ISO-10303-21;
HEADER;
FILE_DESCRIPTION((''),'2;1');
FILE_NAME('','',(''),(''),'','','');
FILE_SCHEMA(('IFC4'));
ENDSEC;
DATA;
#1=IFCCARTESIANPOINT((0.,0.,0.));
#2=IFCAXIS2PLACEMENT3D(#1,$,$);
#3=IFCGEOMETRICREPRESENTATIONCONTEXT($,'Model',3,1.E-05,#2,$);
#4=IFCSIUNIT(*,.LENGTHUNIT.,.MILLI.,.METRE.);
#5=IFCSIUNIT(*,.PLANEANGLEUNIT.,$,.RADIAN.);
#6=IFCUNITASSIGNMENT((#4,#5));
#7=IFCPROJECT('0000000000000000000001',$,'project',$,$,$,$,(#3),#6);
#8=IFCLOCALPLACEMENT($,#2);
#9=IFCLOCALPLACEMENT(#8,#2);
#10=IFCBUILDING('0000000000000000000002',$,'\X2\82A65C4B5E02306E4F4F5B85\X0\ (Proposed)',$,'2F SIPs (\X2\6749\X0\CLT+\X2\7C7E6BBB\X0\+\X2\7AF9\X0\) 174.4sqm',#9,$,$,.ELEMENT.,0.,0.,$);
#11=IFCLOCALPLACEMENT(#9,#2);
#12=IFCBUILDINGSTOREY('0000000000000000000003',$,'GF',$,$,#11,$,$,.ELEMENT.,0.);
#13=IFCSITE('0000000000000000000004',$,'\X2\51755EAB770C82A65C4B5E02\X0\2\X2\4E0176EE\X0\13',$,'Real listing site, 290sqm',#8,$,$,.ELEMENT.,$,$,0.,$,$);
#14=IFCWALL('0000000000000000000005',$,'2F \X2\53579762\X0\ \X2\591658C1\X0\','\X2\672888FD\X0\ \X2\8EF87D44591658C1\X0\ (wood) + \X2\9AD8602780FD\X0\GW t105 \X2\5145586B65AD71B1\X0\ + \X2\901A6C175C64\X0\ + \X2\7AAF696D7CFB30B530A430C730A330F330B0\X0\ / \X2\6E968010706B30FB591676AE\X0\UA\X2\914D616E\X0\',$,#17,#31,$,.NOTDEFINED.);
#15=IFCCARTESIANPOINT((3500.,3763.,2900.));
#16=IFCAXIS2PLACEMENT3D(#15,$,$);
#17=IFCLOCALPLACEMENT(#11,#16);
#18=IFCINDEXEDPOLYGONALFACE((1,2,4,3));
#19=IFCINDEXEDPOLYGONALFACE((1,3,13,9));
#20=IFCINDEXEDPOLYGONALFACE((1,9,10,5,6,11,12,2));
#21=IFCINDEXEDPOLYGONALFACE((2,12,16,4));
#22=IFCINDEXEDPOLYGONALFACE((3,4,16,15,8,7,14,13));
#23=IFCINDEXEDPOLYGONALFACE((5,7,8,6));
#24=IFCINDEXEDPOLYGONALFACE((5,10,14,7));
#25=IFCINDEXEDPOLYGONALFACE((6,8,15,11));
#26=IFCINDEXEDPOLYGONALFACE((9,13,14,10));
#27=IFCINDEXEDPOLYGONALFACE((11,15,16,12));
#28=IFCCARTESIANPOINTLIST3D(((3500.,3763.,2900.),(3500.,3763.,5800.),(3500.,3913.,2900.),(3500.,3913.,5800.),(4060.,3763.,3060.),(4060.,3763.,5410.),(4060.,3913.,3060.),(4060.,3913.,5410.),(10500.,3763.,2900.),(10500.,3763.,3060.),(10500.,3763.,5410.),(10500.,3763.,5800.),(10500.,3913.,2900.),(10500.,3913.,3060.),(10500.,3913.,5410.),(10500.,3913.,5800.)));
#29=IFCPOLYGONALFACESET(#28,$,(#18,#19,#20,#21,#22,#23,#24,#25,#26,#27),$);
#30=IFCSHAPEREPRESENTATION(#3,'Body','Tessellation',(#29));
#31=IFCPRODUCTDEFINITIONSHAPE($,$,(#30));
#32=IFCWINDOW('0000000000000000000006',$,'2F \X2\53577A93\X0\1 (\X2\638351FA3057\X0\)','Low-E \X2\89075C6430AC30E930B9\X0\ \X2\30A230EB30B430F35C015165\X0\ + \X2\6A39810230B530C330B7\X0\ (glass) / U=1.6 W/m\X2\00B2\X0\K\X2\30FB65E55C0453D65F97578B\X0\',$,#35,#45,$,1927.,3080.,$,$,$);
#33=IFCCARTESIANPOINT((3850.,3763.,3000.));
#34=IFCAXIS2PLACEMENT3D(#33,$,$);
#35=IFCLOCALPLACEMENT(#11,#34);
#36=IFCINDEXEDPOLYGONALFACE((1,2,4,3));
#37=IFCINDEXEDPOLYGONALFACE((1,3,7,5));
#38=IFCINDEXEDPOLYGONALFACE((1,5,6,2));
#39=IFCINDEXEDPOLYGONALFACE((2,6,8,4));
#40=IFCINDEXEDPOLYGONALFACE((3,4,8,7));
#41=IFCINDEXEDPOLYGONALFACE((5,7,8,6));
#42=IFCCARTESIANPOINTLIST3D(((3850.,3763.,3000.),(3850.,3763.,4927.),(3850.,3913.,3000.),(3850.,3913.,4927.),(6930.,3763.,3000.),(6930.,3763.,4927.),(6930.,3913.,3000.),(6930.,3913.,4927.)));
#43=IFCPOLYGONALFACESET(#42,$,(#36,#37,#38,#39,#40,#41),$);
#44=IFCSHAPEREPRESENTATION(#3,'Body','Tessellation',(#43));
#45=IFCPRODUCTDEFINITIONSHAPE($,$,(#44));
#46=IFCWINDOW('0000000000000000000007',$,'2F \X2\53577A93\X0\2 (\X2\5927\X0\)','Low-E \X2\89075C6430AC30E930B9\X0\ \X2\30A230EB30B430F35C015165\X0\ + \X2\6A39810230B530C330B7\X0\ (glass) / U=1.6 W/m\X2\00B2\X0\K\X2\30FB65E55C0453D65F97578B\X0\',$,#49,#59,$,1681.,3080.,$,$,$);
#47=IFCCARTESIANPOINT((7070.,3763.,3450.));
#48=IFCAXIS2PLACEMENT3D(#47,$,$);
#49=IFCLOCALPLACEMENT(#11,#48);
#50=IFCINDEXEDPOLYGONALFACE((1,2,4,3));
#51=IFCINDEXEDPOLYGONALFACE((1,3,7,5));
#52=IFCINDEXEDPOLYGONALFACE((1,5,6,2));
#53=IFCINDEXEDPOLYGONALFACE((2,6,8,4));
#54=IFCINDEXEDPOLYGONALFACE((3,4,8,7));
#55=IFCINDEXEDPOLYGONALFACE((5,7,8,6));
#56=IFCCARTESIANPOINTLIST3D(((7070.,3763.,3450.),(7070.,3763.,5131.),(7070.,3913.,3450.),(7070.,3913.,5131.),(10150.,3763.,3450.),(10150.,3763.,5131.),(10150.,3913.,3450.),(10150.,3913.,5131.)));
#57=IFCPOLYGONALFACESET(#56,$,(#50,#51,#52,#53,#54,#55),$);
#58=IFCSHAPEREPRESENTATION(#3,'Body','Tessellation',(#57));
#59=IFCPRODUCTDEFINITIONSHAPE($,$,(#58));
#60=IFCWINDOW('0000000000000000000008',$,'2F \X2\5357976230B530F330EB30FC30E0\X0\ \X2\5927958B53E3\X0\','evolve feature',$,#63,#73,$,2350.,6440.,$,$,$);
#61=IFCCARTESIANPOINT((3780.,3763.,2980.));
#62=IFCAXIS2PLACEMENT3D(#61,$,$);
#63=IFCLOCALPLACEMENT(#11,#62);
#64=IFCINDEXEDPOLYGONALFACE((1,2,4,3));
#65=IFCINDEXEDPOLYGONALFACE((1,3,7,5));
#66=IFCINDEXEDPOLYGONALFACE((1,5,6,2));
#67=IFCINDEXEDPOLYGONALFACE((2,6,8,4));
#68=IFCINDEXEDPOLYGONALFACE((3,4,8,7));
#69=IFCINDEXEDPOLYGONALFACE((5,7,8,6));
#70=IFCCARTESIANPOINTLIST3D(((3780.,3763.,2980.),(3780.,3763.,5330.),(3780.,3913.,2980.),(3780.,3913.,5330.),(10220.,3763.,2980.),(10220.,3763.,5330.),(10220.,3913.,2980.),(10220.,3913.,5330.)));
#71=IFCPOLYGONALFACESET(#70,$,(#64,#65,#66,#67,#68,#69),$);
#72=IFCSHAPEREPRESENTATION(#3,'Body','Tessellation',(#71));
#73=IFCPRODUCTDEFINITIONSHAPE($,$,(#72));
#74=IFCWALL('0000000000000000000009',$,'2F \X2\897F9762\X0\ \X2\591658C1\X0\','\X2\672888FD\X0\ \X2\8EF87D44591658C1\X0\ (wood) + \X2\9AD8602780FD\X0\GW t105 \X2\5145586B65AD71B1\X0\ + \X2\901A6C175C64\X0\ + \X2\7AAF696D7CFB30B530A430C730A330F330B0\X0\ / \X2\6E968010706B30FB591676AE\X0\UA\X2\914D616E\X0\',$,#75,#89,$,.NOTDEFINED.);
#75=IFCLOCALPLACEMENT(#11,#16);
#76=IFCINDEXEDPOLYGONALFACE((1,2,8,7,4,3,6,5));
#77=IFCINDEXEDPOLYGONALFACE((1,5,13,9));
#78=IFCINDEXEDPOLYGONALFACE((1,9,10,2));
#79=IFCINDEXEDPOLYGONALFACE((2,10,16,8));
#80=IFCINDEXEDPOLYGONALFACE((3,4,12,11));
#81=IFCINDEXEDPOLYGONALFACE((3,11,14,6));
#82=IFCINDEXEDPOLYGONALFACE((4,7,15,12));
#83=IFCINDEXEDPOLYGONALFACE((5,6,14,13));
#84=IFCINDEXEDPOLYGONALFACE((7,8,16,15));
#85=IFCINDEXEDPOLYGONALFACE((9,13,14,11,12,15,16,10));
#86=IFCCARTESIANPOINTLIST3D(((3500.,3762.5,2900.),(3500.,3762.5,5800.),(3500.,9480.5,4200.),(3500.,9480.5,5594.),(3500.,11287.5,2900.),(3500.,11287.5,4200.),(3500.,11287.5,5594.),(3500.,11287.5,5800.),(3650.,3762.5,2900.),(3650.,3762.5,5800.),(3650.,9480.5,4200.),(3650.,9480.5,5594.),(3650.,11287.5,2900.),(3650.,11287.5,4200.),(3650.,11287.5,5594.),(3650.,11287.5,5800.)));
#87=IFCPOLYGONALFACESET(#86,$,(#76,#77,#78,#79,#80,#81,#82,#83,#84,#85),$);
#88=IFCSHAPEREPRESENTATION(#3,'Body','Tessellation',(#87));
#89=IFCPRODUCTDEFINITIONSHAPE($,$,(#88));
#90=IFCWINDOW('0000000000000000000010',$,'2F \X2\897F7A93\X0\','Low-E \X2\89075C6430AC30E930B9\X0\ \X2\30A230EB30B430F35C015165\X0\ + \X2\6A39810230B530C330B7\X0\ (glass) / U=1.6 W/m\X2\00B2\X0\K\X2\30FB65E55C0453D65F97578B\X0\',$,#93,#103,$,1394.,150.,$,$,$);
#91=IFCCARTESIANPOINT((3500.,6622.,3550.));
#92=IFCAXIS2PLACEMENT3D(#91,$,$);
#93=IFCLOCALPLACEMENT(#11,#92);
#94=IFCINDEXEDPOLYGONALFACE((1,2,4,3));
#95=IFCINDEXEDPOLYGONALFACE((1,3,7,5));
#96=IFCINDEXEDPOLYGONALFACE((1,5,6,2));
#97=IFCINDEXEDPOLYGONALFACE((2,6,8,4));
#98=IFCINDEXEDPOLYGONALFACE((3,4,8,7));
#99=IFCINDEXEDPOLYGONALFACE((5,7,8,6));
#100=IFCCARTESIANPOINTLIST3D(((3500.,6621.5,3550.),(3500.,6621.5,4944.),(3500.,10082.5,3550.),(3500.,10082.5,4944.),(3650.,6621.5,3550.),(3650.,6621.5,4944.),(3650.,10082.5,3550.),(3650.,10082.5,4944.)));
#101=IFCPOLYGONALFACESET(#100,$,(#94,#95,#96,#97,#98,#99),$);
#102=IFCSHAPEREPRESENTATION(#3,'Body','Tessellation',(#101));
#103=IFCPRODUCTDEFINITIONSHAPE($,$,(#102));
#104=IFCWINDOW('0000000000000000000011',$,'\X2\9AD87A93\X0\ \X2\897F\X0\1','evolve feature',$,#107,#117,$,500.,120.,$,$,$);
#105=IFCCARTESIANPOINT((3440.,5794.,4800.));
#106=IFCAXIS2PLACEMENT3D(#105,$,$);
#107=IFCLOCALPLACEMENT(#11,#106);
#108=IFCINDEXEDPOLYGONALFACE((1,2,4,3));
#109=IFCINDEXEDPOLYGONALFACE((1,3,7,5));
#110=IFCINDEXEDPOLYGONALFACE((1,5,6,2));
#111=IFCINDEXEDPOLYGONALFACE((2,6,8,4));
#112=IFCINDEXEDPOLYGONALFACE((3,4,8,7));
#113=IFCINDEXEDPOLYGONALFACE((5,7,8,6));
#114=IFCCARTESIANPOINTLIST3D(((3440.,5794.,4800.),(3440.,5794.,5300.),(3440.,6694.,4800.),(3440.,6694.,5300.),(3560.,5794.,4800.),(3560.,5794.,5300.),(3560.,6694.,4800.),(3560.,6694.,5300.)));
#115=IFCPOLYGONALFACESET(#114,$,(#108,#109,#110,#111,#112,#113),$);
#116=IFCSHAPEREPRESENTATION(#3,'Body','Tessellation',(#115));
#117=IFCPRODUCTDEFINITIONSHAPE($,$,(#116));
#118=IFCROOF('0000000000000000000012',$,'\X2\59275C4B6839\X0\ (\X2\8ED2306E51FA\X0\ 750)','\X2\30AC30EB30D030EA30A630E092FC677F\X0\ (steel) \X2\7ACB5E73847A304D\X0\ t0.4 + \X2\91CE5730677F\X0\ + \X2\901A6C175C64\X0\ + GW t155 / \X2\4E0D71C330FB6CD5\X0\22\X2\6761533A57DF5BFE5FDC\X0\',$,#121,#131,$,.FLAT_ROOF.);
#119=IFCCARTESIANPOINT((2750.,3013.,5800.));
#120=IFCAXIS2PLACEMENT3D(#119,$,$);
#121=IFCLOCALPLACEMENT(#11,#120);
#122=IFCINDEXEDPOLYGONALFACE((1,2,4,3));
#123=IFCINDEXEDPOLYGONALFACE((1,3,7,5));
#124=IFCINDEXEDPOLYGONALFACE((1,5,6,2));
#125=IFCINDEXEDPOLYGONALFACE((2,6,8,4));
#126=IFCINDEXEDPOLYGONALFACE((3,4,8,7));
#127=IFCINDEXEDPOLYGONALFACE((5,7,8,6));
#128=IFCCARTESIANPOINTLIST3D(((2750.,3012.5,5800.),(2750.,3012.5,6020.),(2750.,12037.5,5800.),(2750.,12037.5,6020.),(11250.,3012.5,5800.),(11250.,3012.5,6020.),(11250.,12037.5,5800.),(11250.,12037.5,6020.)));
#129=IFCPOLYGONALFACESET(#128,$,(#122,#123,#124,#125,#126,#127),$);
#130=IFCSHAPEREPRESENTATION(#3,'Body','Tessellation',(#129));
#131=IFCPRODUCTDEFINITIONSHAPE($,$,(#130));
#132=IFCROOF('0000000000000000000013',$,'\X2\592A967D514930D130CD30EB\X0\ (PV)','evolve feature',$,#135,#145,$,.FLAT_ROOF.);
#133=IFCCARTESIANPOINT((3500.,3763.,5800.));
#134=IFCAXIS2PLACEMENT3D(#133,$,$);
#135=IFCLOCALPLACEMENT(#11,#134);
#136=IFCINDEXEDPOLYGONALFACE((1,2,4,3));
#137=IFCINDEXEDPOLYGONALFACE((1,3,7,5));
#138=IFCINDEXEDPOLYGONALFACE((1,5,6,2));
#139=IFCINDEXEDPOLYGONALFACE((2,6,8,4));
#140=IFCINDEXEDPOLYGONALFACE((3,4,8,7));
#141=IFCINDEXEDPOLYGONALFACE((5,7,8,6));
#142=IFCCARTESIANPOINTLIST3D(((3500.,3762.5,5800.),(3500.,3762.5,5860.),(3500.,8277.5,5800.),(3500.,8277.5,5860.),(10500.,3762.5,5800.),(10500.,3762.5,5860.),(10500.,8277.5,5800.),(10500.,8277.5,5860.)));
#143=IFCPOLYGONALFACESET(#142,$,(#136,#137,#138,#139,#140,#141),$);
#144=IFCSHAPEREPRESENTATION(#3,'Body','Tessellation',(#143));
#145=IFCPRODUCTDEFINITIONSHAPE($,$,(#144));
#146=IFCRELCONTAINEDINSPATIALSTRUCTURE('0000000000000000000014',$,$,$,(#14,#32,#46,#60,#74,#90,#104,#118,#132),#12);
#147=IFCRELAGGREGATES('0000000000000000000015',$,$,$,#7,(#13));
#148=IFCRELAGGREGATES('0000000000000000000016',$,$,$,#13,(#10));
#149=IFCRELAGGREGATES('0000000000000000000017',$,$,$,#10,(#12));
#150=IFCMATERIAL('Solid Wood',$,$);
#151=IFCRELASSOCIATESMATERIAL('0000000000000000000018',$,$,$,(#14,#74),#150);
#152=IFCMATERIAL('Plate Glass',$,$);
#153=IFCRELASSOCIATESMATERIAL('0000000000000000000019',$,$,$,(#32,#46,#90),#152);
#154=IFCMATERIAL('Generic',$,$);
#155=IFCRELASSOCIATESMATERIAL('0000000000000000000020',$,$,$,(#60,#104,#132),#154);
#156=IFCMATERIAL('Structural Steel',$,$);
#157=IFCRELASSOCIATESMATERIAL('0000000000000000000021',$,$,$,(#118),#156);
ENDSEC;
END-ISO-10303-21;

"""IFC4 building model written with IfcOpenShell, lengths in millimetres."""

from ifc_helpers import new_model, si_unit, frame, frame_2d, origin, place, context, project, spatial, rectangle, extrude, material, element, fill, save


model = new_model("IFC4")

# Units and contexts
model_context = context("Model", 3, precision=1e-05, world=origin())
ifc_project = project(units=[si_unit("LENGTHUNIT", "METRE", prefix="MILLI"), si_unit("PLANEANGLEUNIT", "RADIAN")], contexts=[model_context])

# Site, building, storey
site_placement = place(None, origin())
site = spatial("IfcSite", under=ifc_project, at=site_placement, Name="兵庫県芦屋市2丁目13", ObjectType="Real listing site, 290sqm", CompositionType="ELEMENT", RefElevation=0.0)
building_placement = place(site_placement, origin())
building = spatial("IfcBuilding", under=site, at=building_placement, Name="芦屋市の住宅 (Proposed)", ObjectType="2F SIPs (杉CLT+籾殻+竹) 174.4sqm", CompositionType="ELEMENT", ElevationOfRefHeight=0.0, ElevationOfTerrain=0.0)
storey_placement = place(building_placement, origin())
storey = spatial("IfcBuildingStorey", under=building, at=storey_placement, Name="GF", CompositionType="ELEMENT", Elevation=0.0)

# Shared definitions
ifc_material_1 = material(Name="Solid Wood")
ifc_material_2 = material(Name="Generic")

# Shared definitions
ifc_material_3 = material(Name="Plate Glass")

# Walls, openings, windows
wall_1_placement = place(storey_placement, frame((3500.0, 3763.0, 2900.0)))
wall_1 = element("IfcWall", 1, at=wall_1_placement, inside=storey, material=ifc_material_1, Name="2F 南面 外壁", Description="木製 軸組外壁 (wood) + 高性能GW t105 充填断熱 + 通気層 + 窯業系サイディング / 準耐火・外皮UA配慮", PredefinedType="NOTDEFINED", context=model_context, shape_type="SweptSolid", body=[
    extrude(rectangle(XDim=7000.0, YDim=150.0, at=frame_2d((3500.0, 75.0))), frame((3500.0, 3763.0, 2900.0)), (0.0, 0.0, 1.0), 2900.0),
])
opening_1_placement = place(storey_placement, frame((3850.0, 3763.0, 3000.0)))
opening_1 = element("IfcOpeningElement", 2, at=opening_1_placement, cuts=wall_1, PredefinedType="NOTDEFINED", context=model_context, shape_type="SweptSolid", body=[
    extrude(rectangle(XDim=3080.0, YDim=150.0, at=frame_2d((1540.0, 75.0))), frame((3850.0, 3763.0, 3000.0)), (0.0, 0.0, 1.0), 1927.0),
])
opening_2_placement = place(storey_placement, frame((7070.0, 3763.0, 3450.0)))
opening_2 = element("IfcOpeningElement", 3, at=opening_2_placement, cuts=wall_1, PredefinedType="NOTDEFINED", context=model_context, shape_type="SweptSolid", body=[
    extrude(rectangle(XDim=3080.0, YDim=150.0, at=frame_2d((1540.0, 75.0))), frame((7070.0, 3763.0, 3450.0)), (0.0, 0.0, 1.0), 1681.0),
])
opening_3_placement = place(storey_placement, frame((3780.0, 3763.0, 2980.0)))
opening_3 = element("IfcOpeningElement", 4, at=opening_3_placement, cuts=wall_1, PredefinedType="NOTDEFINED", context=model_context, shape_type="SweptSolid", body=[
    extrude(rectangle(XDim=6440.0, YDim=150.0, at=frame_2d((3220.0, 75.0))), frame((3780.0, 3763.0, 2980.0)), (0.0, 0.0, 1.0), 2350.0),
])
window_1_placement = place(storey_placement, frame((3850.0, 3763.0, 3000.0)))
window_1 = element("IfcWindow", 5, at=window_1_placement, inside=storey, material=ifc_material_3, Name="2F 南窓1 (掃出し)", Description="Low-E 複層ガラス アルゴン封入 + 樹脂サッシ (glass) / U=1.6 W/m²K・日射取得型", OverallHeight=1927.0, OverallWidth=3080.0, context=model_context, shape_type="SweptSolid", body=[
    extrude(rectangle(XDim=3080.0, YDim=150.0, at=frame_2d((1540.0, 75.0))), frame((3850.0, 3763.0, 3000.0)), (0.0, 0.0, 1.0), 1927.0),
])
fill(opening_1, window_1)
window_2_placement = place(storey_placement, frame((7070.0, 3763.0, 3450.0)))
window_2 = element("IfcWindow", 6, at=window_2_placement, inside=storey, material=ifc_material_3, Name="2F 南窓2 (大)", Description="Low-E 複層ガラス アルゴン封入 + 樹脂サッシ (glass) / U=1.6 W/m²K・日射取得型", OverallHeight=1681.0, OverallWidth=3080.0, context=model_context, shape_type="SweptSolid", body=[
    extrude(rectangle(XDim=3080.0, YDim=150.0, at=frame_2d((1540.0, 75.0))), frame((7070.0, 3763.0, 3450.0)), (0.0, 0.0, 1.0), 1681.0),
])
fill(opening_2, window_2)
window_3_placement = place(storey_placement, frame((3780.0, 3763.0, 2980.0)))
window_3 = element("IfcWindow", 7, at=window_3_placement, inside=storey, material=ifc_material_2, Name="2F 南面サンルーム 大開口", Description="evolve feature", OverallHeight=2350.0, OverallWidth=6440.0, context=model_context, shape_type="SweptSolid", body=[
    extrude(rectangle(XDim=6440.0, YDim=150.0, at=frame_2d((3220.0, 75.0))), frame((3780.0, 3763.0, 2980.0)), (0.0, 0.0, 1.0), 2350.0),
])
fill(opening_3, window_3)
wall_2_placement = place(storey_placement, frame((3500.0, 3763.0, 2900.0)))
wall_2 = element("IfcWall", 8, at=wall_2_placement, inside=storey, material=ifc_material_1, Name="2F 西面 外壁", Description="木製 軸組外壁 (wood) + 高性能GW t105 充填断熱 + 通気層 + 窯業系サイディング / 準耐火・外皮UA配慮", PredefinedType="NOTDEFINED", context=model_context, shape_type="SweptSolid", body=[
    extrude(rectangle(XDim=150.0, YDim=7525.0, at=frame_2d((75.0, 3762.0))), frame((3500.0, 3763.0, 2900.0)), (0.0, 0.0, 1.0), 2900.0),
])
opening_4_placement = place(storey_placement, frame((3500.0, 6622.0, 3550.0)))
opening_4 = element("IfcOpeningElement", 9, at=opening_4_placement, cuts=wall_2, PredefinedType="NOTDEFINED", context=model_context, shape_type="SweptSolid", body=[
    extrude(rectangle(XDim=150.0, YDim=3461.0, at=frame_2d((75.0, 1730.0))), frame((3500.0, 6622.0, 3550.0)), (0.0, 0.0, 1.0), 1394.0),
])
opening_5_placement = place(storey_placement, frame((3440.0, 5794.0, 4800.0)))
opening_5 = element("IfcOpeningElement", 10, at=opening_5_placement, cuts=wall_2, PredefinedType="NOTDEFINED", context=model_context, shape_type="SweptSolid", body=[
    extrude(rectangle(XDim=120.0, YDim=900.0, at=frame_2d((60.0, 450.0))), frame((3440.0, 5794.0, 4800.0)), (0.0, 0.0, 1.0), 500.0),
])
window_4_placement = place(storey_placement, frame((3500.0, 6622.0, 3550.0)))
window_4 = element("IfcWindow", 11, at=window_4_placement, inside=storey, material=ifc_material_3, Name="2F 西窓", Description="Low-E 複層ガラス アルゴン封入 + 樹脂サッシ (glass) / U=1.6 W/m²K・日射取得型", OverallHeight=1394.0, OverallWidth=150.0, context=model_context, shape_type="SweptSolid", body=[
    extrude(rectangle(XDim=150.0, YDim=3461.0, at=frame_2d((75.0, 1730.0))), frame((3500.0, 6622.0, 3550.0)), (0.0, 0.0, 1.0), 1394.0),
])
fill(opening_4, window_4)
window_5_placement = place(storey_placement, frame((3440.0, 5794.0, 4800.0)))
window_5 = element("IfcWindow", 12, at=window_5_placement, inside=storey, material=ifc_material_2, Name="高窓 西1", Description="evolve feature", OverallHeight=500.0, OverallWidth=120.0, context=model_context, shape_type="SweptSolid", body=[
    extrude(rectangle(XDim=120.0, YDim=900.0, at=frame_2d((60.0, 450.0))), frame((3440.0, 5794.0, 4800.0)), (0.0, 0.0, 1.0), 500.0),
])
fill(opening_5, window_5)

# Roofs
ifc_material_4 = material(Name="Structural Steel")
roof_1_placement = place(storey_placement, frame((2750.0, 3013.0, 5800.0)))
element("IfcRoof", 13, at=roof_1_placement, inside=storey, material=ifc_material_4, Name="大屋根 (軒の出 750)", Description="ガルバリウム鋼板 (steel) 立平葺き t0.4 + 野地板 + 通気層 + GW t155 / 不燃・法22条区域対応", PredefinedType="FLAT_ROOF", context=model_context, shape_type="SweptSolid", body=[
    extrude(rectangle(XDim=8500.0, YDim=9025.0, at=frame_2d((4250.0, 4512.0))), frame((2750.0, 3013.0, 5800.0)), (0.0, 0.0, 1.0), 220.0),
])
roof_2_placement = place(storey_placement, frame((3500.0, 3763.0, 5800.0)))
element("IfcRoof", 14, at=roof_2_placement, inside=storey, material=ifc_material_2, Name="太陽光パネル (PV)", Description="evolve feature", PredefinedType="FLAT_ROOF", context=model_context, shape_type="SweptSolid", body=[
    extrude(rectangle(XDim=7000.0, YDim=4515.0, at=frame_2d((3500.0, 2257.0))), frame((3500.0, 3763.0, 5800.0)), (0.0, 0.0, 1.0), 60.0),
])

save(model, "model.ifc")
